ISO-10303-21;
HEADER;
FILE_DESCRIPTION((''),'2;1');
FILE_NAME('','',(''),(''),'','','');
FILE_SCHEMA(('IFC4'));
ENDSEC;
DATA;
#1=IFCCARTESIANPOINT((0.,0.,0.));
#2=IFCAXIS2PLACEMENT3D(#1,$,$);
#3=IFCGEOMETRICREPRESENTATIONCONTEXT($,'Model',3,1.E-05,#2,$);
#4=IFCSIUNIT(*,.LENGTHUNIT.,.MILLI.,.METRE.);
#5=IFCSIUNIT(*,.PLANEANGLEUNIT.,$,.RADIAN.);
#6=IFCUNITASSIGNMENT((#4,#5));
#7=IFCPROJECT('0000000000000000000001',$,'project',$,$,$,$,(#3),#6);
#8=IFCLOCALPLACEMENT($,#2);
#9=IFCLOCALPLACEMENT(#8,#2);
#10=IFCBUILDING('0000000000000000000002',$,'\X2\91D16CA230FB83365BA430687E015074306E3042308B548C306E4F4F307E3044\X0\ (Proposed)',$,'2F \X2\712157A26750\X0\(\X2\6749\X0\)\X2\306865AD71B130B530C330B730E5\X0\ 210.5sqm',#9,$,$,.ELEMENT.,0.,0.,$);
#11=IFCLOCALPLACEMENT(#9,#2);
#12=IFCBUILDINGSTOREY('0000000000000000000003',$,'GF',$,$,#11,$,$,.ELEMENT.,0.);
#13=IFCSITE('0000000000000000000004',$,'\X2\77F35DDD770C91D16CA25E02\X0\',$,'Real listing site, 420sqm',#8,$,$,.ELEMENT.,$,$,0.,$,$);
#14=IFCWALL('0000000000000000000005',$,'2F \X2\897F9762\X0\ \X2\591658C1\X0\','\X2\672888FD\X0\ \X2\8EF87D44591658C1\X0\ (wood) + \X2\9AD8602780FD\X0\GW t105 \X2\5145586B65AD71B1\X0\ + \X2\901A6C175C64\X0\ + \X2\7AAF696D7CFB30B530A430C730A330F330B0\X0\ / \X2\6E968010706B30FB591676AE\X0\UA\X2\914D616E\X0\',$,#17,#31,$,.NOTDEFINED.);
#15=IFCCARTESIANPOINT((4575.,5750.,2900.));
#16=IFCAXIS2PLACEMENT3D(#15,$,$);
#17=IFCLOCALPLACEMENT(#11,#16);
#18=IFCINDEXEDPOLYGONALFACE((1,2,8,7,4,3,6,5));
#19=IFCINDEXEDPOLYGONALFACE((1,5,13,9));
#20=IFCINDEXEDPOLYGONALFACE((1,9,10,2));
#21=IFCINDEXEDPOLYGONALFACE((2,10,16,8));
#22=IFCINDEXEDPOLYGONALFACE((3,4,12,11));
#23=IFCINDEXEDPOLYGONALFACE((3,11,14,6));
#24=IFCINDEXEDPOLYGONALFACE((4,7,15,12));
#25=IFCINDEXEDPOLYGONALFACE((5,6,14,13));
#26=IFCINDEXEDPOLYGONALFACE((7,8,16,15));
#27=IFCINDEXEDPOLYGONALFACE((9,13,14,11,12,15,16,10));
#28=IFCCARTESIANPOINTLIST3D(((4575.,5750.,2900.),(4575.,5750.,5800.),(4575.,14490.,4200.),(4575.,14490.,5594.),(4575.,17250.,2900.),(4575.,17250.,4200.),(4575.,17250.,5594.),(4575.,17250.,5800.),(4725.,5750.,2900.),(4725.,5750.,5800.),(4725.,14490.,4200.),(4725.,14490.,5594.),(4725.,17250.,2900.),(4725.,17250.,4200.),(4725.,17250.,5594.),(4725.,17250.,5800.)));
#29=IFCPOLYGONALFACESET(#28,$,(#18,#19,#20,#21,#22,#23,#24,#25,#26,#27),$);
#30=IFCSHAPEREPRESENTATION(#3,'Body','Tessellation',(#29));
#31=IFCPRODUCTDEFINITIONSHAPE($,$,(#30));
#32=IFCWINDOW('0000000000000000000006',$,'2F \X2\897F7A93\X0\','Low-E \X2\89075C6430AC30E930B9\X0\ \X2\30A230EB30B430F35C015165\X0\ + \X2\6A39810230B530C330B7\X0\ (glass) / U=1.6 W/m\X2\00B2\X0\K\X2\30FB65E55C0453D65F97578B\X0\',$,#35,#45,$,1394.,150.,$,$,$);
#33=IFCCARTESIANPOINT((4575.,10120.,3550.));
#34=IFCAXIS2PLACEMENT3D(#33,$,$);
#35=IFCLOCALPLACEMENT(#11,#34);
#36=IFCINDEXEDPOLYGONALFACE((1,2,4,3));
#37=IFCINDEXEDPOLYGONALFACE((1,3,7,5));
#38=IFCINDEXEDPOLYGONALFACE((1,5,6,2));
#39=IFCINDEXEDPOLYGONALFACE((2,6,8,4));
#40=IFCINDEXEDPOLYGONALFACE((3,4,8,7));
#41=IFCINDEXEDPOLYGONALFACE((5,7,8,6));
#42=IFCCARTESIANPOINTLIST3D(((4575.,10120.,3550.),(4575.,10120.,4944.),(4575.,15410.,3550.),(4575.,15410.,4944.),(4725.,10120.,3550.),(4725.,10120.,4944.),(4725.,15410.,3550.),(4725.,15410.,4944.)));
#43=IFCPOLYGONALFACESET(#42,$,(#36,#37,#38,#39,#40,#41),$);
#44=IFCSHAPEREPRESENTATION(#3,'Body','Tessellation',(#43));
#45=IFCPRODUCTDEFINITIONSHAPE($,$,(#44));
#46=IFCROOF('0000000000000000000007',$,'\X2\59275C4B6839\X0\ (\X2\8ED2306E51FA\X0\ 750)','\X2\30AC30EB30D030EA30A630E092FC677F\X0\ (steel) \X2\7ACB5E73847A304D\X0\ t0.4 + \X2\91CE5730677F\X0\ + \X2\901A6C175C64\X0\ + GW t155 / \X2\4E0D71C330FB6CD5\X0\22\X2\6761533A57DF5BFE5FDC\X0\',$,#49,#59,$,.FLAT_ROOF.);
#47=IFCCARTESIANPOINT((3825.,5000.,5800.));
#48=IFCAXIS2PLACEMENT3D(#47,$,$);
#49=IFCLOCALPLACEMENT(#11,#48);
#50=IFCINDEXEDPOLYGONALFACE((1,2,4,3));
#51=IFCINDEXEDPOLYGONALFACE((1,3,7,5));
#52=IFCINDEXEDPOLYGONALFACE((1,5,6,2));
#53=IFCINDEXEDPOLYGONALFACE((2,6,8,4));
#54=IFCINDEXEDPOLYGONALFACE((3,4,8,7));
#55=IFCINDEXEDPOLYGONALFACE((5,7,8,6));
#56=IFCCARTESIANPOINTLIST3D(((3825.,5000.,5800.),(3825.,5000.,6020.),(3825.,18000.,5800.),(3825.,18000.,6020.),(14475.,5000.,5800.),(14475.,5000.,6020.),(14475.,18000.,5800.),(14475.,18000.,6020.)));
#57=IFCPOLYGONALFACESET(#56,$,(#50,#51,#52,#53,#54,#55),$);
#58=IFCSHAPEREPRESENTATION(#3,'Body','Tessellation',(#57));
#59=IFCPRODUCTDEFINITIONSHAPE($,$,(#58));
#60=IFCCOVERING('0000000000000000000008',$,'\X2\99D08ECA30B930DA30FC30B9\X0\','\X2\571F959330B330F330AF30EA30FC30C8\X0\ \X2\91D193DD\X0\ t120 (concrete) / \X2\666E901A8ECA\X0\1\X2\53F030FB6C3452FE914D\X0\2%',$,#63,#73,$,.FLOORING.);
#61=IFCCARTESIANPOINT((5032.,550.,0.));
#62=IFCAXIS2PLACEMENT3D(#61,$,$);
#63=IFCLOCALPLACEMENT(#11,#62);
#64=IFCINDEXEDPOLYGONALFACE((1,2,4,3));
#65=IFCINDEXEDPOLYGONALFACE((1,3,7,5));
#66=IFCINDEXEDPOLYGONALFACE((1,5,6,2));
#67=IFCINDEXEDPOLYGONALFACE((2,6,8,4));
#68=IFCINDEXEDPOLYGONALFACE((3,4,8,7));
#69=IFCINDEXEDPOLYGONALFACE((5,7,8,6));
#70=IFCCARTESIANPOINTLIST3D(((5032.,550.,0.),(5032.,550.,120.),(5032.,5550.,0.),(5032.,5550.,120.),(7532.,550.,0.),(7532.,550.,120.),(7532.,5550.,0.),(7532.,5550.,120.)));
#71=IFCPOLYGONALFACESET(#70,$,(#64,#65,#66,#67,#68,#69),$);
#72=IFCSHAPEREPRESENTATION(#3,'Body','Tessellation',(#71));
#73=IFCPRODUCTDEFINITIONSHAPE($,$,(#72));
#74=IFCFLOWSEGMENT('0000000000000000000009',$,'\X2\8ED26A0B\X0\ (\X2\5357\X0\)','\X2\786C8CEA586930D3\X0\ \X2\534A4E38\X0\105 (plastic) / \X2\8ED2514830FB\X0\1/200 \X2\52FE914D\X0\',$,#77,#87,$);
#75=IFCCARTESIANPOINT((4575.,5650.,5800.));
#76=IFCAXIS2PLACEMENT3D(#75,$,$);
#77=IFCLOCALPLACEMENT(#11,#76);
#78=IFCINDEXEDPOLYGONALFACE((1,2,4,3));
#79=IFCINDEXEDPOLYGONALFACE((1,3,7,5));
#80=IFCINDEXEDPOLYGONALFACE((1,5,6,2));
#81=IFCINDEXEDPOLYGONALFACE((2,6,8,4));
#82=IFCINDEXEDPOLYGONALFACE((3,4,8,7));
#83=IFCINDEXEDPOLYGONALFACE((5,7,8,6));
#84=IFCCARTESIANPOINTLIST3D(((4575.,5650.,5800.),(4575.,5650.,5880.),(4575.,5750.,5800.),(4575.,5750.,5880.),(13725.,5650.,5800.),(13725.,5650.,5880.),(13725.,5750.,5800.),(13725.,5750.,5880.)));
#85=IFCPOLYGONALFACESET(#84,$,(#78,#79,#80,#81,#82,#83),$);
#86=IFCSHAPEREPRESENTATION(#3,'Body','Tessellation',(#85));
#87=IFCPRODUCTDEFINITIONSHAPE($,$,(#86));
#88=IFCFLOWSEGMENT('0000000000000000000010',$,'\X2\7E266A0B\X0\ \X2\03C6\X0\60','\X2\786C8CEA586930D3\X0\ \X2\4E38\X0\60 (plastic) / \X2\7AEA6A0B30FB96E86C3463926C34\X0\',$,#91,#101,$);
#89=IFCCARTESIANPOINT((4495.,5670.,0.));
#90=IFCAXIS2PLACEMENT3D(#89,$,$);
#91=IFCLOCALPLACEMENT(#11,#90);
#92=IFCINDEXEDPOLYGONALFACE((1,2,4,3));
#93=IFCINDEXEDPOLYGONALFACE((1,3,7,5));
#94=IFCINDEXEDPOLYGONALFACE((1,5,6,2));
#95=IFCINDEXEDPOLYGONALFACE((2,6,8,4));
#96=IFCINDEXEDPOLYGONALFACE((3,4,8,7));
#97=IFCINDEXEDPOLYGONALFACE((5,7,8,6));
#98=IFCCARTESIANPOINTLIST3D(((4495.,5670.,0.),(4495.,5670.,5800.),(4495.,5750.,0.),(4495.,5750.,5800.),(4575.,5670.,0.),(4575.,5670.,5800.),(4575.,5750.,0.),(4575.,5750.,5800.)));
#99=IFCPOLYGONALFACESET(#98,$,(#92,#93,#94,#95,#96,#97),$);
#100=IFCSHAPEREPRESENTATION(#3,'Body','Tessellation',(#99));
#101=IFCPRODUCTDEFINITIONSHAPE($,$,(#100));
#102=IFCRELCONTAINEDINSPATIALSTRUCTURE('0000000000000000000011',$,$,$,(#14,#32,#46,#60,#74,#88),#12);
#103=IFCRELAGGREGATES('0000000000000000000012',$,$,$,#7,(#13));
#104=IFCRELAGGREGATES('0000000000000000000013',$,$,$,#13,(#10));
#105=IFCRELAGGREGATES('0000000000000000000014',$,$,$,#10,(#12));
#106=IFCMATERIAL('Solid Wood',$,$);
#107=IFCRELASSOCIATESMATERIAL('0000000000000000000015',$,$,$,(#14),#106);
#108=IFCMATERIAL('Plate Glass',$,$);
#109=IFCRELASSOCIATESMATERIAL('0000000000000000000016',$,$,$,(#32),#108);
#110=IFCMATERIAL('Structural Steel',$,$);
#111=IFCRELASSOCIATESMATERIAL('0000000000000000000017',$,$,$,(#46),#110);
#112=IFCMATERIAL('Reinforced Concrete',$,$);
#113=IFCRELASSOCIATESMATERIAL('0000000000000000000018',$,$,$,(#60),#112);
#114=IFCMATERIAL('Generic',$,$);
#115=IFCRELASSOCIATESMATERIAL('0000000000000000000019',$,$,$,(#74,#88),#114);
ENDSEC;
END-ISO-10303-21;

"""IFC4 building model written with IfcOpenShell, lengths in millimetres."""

from ifc_helpers import new_model, si_unit, frame, frame_2d, origin, place, context, project, spatial, rectangle, extrude, material, element, fill, save


model = new_model("IFC4")

# Units and contexts
model_context = context("Model", 3, precision=1e-05, world=origin())
ifc_project = project(units=[si_unit("LENGTHUNIT", "METRE", prefix="MILLI"), si_unit("PLANEANGLEUNIT", "RADIAN")], contexts=[model_context])

# Site, building, storey
site_placement = place(None, origin())
site = spatial("IfcSite", under=ifc_project, at=site_placement, Name="石川県金沢市", ObjectType="Real listing site, 420sqm", CompositionType="ELEMENT", RefElevation=0.0)
building_placement = place(site_placement, origin())
building = spatial("IfcBuilding", under=site, at=building_placement, Name="金沢・茶室と縁側のある和の住まい (Proposed)", ObjectType="2F 無垢材(杉)と断熱サッシュ 210.5sqm", CompositionType="ELEMENT", ElevationOfRefHeight=0.0, ElevationOfTerrain=0.0)
storey_placement = place(building_placement, origin())
storey = spatial("IfcBuildingStorey", under=building, at=storey_placement, Name="GF", CompositionType="ELEMENT", Elevation=0.0)

# Shared definitions
ifc_material_1 = material(Name="Solid Wood")

# Shared definitions
ifc_material_2 = material(Name="Reinforced Concrete")

# Shared definitions
ifc_material_3 = material(Name="Plate Glass")

# Wall, opening, window
wall_1_placement = place(storey_placement, frame((4575.0, 5750.0, 2900.0)))
wall_1 = element("IfcWall", 1, at=wall_1_placement, inside=storey, material=ifc_material_1, Name="2F 西面 外壁", Description="木製 軸組外壁 (wood) + 高性能GW t105 充填断熱 + 通気層 + 窯業系サイディング / 準耐火・外皮UA配慮", PredefinedType="NOTDEFINED", context=model_context, shape_type="SweptSolid", body=[
    extrude(rectangle(XDim=150.0, YDim=11500.0, at=frame_2d((75.0, 5750.0))), frame((4575.0, 5750.0, 2900.0)), (0.0, 0.0, 1.0), 2900.0),
])
opening_1_placement = place(storey_placement, frame((4575.0, 10120.0, 3550.0)))
opening_1 = element("IfcOpeningElement", 2, at=opening_1_placement, cuts=wall_1, PredefinedType="NOTDEFINED", context=model_context, shape_type="SweptSolid", body=[
    extrude(rectangle(XDim=150.0, YDim=5290.0, at=frame_2d((75.0, 2645.0))), frame((4575.0, 10120.0, 3550.0)), (0.0, 0.0, 1.0), 1394.0),
])
window_1_placement = place(storey_placement, frame((4575.0, 10120.0, 3550.0)))
window_1 = element("IfcWindow", 3, at=window_1_placement, inside=storey, material=ifc_material_3, Name="2F 西窓", Description="Low-E 複層ガラス アルゴン封入 + 樹脂サッシ (glass) / U=1.6 W/m²K・日射取得型", OverallHeight=1394.0, OverallWidth=150.0, context=model_context, shape_type="SweptSolid", body=[
    extrude(rectangle(XDim=150.0, YDim=5290.0, at=frame_2d((75.0, 2645.0))), frame((4575.0, 10120.0, 3550.0)), (0.0, 0.0, 1.0), 1394.0),
])
fill(opening_1, window_1)

# Roof
ifc_material_4 = material(Name="Structural Steel")
roof_placement = place(storey_placement, frame((3825.0, 5000.0, 5800.0)))
element("IfcRoof", 4, at=roof_placement, inside=storey, material=ifc_material_4, Name="大屋根 (軒の出 750)", Description="ガルバリウム鋼板 (steel) 立平葺き t0.4 + 野地板 + 通気層 + GW t155 / 不燃・法22条区域対応", PredefinedType="FLAT_ROOF", context=model_context, shape_type="SweptSolid", body=[
    extrude(rectangle(XDim=10650.0, YDim=13000.0, at=frame_2d((5325.0, 6500.0))), frame((3825.0, 5000.0, 5800.0)), (0.0, 0.0, 1.0), 220.0),
])

# Covering
covering_placement = place(storey_placement, frame((5032.0, 550.0, 0.0)))
element("IfcCovering", 5, at=covering_placement, inside=storey, material=ifc_material_2, Name="駐車スペース", Description="土間コンクリート 金鏝 t120 (concrete) / 普通車1台・水勾配2%", PredefinedType="FLOORING", context=model_context, shape_type="SweptSolid", body=[
    extrude(rectangle(XDim=2500.0, YDim=5000.0, at=frame_2d((1250.0, 2500.0))), frame((5032.0, 550.0, 0.0)), (0.0, 0.0, 1.0), 120.0),
])

# Flow segments
ifc_material_5 = material(Name="Generic")
flow_segment_1_placement = place(storey_placement, frame((4575.0, 5650.0, 5800.0)))
element("IfcFlowSegment", 6, at=flow_segment_1_placement, inside=storey, material=ifc_material_5, Name="軒樋 (南)", Description="硬質塩ビ 半丸105 (plastic) / 軒先・1/200 勾配", context=model_context, shape_type="SweptSolid", body=[
    extrude(rectangle(XDim=9150.0, YDim=100.0, at=frame_2d((4575.0, 50.0))), frame((4575.0, 5650.0, 5800.0)), (0.0, 0.0, 1.0), 80.0),
])
flow_segment_2_placement = place(storey_placement, frame((4495.0, 5670.0, 0.0)))
element("IfcFlowSegment", 7, at=flow_segment_2_placement, inside=storey, material=ifc_material_5, Name="縦樋 φ60", Description="硬質塩ビ 丸60 (plastic) / 竪樋・雨水排水", context=model_context, shape_type="SweptSolid", body=[
    extrude(rectangle(XDim=80.0, YDim=80.0, at=frame_2d((40.0, 40.0))), frame((4495.0, 5670.0, 0.0)), (0.0, 0.0, 1.0), 5800.0),
])

save(model, "model.ifc")
